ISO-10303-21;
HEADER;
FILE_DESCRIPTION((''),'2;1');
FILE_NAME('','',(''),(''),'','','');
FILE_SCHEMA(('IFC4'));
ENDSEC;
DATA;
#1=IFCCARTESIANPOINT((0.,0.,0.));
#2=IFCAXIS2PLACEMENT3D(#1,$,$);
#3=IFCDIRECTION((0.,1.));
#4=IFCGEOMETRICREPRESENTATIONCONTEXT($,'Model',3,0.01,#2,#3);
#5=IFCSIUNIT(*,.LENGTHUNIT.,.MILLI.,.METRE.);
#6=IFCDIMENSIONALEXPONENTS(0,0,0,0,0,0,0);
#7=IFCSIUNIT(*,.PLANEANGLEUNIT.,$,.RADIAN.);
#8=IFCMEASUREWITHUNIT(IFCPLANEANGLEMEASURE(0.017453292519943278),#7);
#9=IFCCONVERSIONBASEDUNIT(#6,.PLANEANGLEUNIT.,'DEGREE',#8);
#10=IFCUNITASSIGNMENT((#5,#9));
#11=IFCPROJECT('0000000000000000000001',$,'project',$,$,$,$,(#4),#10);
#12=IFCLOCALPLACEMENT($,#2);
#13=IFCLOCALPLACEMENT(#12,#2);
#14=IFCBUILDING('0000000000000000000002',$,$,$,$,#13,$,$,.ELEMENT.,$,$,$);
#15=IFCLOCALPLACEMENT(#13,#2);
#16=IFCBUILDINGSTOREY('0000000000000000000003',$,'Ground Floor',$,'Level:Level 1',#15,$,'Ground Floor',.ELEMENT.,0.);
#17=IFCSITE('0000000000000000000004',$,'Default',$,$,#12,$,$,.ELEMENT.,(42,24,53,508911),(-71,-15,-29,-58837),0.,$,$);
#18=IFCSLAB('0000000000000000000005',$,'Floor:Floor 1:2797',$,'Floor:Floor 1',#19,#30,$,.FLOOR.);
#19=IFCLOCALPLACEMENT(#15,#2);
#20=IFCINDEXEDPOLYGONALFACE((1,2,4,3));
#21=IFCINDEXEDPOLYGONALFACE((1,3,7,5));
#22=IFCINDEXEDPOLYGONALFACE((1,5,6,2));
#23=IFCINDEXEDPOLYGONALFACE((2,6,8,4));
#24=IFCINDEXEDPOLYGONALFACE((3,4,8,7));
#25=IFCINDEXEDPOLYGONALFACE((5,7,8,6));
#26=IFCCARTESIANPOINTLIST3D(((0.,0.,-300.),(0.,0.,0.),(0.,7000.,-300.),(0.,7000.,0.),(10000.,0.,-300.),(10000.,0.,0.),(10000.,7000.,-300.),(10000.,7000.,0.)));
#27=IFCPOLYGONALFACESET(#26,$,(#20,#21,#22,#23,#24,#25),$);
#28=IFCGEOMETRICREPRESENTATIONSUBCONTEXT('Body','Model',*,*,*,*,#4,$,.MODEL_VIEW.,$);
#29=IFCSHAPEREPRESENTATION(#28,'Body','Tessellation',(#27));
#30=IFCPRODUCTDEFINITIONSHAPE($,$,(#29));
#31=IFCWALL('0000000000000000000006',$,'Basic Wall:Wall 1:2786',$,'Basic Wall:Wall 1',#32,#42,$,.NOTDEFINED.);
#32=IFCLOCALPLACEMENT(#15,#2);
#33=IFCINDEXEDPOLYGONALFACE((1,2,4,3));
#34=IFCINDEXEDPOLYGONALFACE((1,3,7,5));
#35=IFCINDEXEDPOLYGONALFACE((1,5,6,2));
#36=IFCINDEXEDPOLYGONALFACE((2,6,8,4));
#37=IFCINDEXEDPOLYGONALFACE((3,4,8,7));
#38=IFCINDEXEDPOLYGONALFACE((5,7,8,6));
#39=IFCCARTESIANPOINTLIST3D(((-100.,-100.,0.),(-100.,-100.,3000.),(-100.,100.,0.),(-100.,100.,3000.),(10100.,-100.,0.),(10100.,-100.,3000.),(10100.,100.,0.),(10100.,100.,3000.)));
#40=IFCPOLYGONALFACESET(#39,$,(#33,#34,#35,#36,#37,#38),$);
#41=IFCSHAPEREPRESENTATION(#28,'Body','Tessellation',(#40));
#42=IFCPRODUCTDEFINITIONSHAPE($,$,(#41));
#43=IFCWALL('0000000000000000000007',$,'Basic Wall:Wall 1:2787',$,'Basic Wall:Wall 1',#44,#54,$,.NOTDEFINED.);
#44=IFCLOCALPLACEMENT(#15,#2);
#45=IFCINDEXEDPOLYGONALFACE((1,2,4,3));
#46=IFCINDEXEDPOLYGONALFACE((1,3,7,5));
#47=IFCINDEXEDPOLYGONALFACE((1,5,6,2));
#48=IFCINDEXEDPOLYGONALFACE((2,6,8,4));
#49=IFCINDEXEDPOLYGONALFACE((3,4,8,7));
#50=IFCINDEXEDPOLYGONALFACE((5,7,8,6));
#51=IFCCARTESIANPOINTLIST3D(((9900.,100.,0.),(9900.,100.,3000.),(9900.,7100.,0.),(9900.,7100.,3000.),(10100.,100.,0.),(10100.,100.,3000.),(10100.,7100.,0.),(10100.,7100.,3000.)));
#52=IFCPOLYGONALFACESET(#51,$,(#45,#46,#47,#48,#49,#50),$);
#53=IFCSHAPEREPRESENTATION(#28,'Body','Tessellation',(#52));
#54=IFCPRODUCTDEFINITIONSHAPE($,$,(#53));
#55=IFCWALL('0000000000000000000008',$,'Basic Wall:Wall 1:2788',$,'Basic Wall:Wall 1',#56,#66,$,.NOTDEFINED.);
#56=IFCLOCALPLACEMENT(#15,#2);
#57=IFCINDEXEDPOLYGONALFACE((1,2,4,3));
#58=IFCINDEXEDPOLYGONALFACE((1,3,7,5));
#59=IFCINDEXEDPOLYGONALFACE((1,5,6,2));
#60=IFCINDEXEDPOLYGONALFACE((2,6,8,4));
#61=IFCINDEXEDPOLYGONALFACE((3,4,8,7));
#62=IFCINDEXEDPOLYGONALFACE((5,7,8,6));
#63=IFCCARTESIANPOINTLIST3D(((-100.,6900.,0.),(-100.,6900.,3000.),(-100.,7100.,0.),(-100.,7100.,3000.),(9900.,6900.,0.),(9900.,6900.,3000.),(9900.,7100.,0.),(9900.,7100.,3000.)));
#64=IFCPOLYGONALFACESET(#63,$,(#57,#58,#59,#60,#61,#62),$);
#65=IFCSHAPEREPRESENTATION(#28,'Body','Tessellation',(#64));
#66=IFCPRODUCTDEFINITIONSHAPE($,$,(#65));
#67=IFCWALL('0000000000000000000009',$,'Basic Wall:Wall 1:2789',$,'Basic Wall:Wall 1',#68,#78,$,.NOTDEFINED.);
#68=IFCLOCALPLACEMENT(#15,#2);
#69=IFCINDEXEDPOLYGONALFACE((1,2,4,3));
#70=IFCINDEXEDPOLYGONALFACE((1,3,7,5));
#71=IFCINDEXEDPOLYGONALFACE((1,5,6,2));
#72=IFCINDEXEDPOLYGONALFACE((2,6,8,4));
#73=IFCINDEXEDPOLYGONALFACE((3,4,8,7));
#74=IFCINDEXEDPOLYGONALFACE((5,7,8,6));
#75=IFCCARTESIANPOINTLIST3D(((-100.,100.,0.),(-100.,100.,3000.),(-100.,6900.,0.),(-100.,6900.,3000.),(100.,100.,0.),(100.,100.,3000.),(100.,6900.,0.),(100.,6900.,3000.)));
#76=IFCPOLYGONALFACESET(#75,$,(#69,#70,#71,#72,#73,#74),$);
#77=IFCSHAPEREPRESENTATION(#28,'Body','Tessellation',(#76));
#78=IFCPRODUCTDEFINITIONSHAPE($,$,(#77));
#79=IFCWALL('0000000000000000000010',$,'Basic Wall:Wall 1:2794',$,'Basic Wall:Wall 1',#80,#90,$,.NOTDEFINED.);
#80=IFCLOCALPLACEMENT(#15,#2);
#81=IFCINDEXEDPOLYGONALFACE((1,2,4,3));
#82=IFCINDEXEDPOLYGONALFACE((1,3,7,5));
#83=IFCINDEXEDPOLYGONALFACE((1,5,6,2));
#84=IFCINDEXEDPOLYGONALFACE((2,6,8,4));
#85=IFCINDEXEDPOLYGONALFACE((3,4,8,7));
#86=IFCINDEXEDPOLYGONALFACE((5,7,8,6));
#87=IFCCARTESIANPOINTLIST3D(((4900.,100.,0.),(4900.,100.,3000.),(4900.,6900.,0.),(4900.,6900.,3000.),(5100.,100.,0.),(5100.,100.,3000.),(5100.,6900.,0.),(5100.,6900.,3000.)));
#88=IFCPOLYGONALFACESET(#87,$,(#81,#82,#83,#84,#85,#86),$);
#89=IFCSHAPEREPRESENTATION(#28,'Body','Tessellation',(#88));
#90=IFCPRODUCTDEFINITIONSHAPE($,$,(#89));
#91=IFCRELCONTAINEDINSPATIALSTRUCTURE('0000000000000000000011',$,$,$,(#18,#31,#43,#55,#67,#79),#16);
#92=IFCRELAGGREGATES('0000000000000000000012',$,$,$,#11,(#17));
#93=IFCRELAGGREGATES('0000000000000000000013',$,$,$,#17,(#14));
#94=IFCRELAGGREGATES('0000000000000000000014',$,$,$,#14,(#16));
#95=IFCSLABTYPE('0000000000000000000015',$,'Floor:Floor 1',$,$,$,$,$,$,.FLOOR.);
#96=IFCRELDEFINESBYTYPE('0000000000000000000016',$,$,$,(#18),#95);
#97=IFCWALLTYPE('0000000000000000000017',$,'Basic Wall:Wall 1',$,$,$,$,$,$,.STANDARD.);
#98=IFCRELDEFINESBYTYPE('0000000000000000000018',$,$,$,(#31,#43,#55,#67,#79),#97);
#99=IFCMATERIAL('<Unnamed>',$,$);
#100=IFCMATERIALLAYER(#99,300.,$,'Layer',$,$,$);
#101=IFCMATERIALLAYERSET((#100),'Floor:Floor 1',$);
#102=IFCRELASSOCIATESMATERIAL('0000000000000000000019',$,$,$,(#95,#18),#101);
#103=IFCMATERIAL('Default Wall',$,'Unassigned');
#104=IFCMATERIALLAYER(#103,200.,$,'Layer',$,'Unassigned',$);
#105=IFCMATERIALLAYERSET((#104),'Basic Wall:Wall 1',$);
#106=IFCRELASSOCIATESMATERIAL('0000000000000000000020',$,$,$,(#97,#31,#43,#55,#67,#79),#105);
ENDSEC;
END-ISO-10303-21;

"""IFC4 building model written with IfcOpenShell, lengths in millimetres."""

from ifc_helpers import new_model, entity, si_unit, converted_unit, direction, frame, frame_2d, origin, origin_2d_with_axis, place, context, subcontext, project, spatial, rectangle, extrude, material, layer, layer_set, layer_usage, type_object, element, save


model = new_model("IFC4")

# Units and contexts
model_context = context("Model", 3, precision=0.01, world=origin(), true_north=direction((0.0, 1.0)))
body_context = subcontext(model_context, "Body", "Model", "MODEL_VIEW")
ifc_project = project(units=[si_unit("LENGTHUNIT", "METRE", prefix="MILLI"), converted_unit("PLANEANGLEUNIT", "DEGREE", entity("IfcPlaneAngleMeasure", 0.017453292519943278), si_unit("PLANEANGLEUNIT", "RADIAN"), dimensions=[0, 0, 0, 0, 0, 0, 0])], contexts=[model_context])

# Site, building, storey
site_placement = place(None, origin())
site = spatial("IfcSite", under=ifc_project, at=site_placement, Name="Default", CompositionType="ELEMENT", RefLatitude=(42, 24, 53, 508911), RefLongitude=(-71, -15, -29, -58837), RefElevation=0.0)
building_placement = place(site_placement, origin())
building = spatial("IfcBuilding", under=site, at=building_placement, CompositionType="ELEMENT")
storey_placement = place(building_placement, origin())
storey = spatial("IfcBuildingStorey", under=building, at=storey_placement, Name="Ground Floor", ObjectType="Level:Level 1", LongName="Ground Floor", CompositionType="ELEMENT", Elevation=0.0)

# Slab
ifc_material_1 = material(Name="<Unnamed>")
ifc_layer_1 = layer(ifc_material_1, 300.0, Name="Layer")
ifc_layer_set_1 = layer_set([ifc_layer_1], Name="Floor:Floor 1")
ifc_layer_usage_1 = layer_usage(ifc_layer_set_1, "AXIS3", "POSITIVE", 0.0)
slab_type = type_object("IfcSlabType", Name="Floor:Floor 1", PredefinedType="FLOOR", material=ifc_layer_set_1)
slab_placement = place(storey_placement, origin())
element("IfcSlab", 1, at=slab_placement, inside=storey, type_object=slab_type, material=ifc_layer_usage_1, Name="Floor:Floor 1:2797", ObjectType="Floor:Floor 1", PredefinedType="FLOOR", context=body_context, shape_type="SweptSolid", body=[
    extrude(rectangle(XDim=7000.0, YDim=10000.0, at=origin_2d_with_axis()), frame((5000.0, 3500.0, 0.0), z_axis=(0.0, 0.0, -1.0), x_axis=(0.0, 1.0, 0.0)), (0.0, 0.0, 1.0), 300.0),
])

# Walls
ifc_material_2 = material(Name="Default Wall", Category="Unassigned")
ifc_layer_2 = layer(ifc_material_2, 200.0, Name="Layer", Category="Unassigned")
ifc_layer_set_2 = layer_set([ifc_layer_2], Name="Basic Wall:Wall 1")
ifc_layer_usage_2 = layer_usage(ifc_layer_set_2, "AXIS2", "NEGATIVE", 100.0)
wall_type = type_object("IfcWallType", Name="Basic Wall:Wall 1", PredefinedType="STANDARD", material=ifc_layer_set_2)
wall_1_placement = place(storey_placement, frame((-100.0, 0.0, 0.0)))
element("IfcWall", 2, at=wall_1_placement, inside=storey, type_object=wall_type, material=ifc_layer_usage_2, Name="Basic Wall:Wall 1:2786", ObjectType="Basic Wall:Wall 1", PredefinedType="NOTDEFINED", context=body_context, shape_type="SweptSolid", body=[
    extrude(rectangle(XDim=10200.0, YDim=200.0, at=frame_2d((5100.0, 0.0), x_axis=(-1.0, 0.0))), origin(), (0.0, 0.0, 1.0), 3000.0),
])
ifc_layer_usage_3 = layer_usage(ifc_layer_set_2, "AXIS2", "NEGATIVE", 100.0)
wall_2_placement = place(storey_placement, frame((10000.0, 100.0, 0.0), z_axis=(0.0, 0.0, 1.0), x_axis=(0.0, 1.0, 0.0)))
element("IfcWall", 3, at=wall_2_placement, inside=storey, type_object=wall_type, material=ifc_layer_usage_3, Name="Basic Wall:Wall 1:2787", ObjectType="Basic Wall:Wall 1", PredefinedType="NOTDEFINED", context=body_context, shape_type="SweptSolid", body=[
    extrude(rectangle(XDim=7000.0, YDim=200.0, at=frame_2d((3500.0, 0.0), x_axis=(-1.0, 0.0))), origin(), (0.0, 0.0, 1.0), 3000.0),
])
ifc_layer_usage_4 = layer_usage(ifc_layer_set_2, "AXIS2", "NEGATIVE", 100.0)
wall_3_placement = place(storey_placement, frame((9900.0, 7000.0, 0.0), z_axis=(0.0, 0.0, 1.0), x_axis=(-1.0, 0.0, 0.0)))
element("IfcWall", 4, at=wall_3_placement, inside=storey, type_object=wall_type, material=ifc_layer_usage_4, Name="Basic Wall:Wall 1:2788", ObjectType="Basic Wall:Wall 1", PredefinedType="NOTDEFINED", context=body_context, shape_type="SweptSolid", body=[
    extrude(rectangle(XDim=10000.0, YDim=200.0, at=frame_2d((5000.0, 0.0), x_axis=(-1.0, 0.0))), origin(), (0.0, 0.0, 1.0), 3000.0),
])
ifc_layer_usage_5 = layer_usage(ifc_layer_set_2, "AXIS2", "NEGATIVE", 100.0)
wall_4_placement = place(storey_placement, frame((0.0, 6900.0, 0.0), z_axis=(0.0, 0.0, 1.0), x_axis=(0.0, -1.0, 0.0)))
element("IfcWall", 5, at=wall_4_placement, inside=storey, type_object=wall_type, material=ifc_layer_usage_5, Name="Basic Wall:Wall 1:2789", ObjectType="Basic Wall:Wall 1", PredefinedType="NOTDEFINED", context=body_context, shape_type="SweptSolid", body=[
    extrude(rectangle(XDim=6800.0, YDim=200.0, at=frame_2d((3400.0, 0.0), x_axis=(-1.0, 0.0))), origin(), (0.0, 0.0, 1.0), 3000.0),
])
ifc_layer_usage_6 = layer_usage(ifc_layer_set_2, "AXIS2", "NEGATIVE", 100.0)
wall_5_placement = place(storey_placement, frame((5000.0, 100.0, 0.0), z_axis=(0.0, 0.0, 1.0), x_axis=(0.0, 1.0, 0.0)))
element("IfcWall", 6, at=wall_5_placement, inside=storey, type_object=wall_type, material=ifc_layer_usage_6, Name="Basic Wall:Wall 1:2794", ObjectType="Basic Wall:Wall 1", PredefinedType="NOTDEFINED", context=body_context, shape_type="SweptSolid", body=[
    extrude(rectangle(XDim=6800.0, YDim=200.0, at=frame_2d((3400.0, 0.0), x_axis=(-1.0, 0.0))), origin(), (0.0, 0.0, 1.0), 3000.0),
])

save(model, "model.ifc")
